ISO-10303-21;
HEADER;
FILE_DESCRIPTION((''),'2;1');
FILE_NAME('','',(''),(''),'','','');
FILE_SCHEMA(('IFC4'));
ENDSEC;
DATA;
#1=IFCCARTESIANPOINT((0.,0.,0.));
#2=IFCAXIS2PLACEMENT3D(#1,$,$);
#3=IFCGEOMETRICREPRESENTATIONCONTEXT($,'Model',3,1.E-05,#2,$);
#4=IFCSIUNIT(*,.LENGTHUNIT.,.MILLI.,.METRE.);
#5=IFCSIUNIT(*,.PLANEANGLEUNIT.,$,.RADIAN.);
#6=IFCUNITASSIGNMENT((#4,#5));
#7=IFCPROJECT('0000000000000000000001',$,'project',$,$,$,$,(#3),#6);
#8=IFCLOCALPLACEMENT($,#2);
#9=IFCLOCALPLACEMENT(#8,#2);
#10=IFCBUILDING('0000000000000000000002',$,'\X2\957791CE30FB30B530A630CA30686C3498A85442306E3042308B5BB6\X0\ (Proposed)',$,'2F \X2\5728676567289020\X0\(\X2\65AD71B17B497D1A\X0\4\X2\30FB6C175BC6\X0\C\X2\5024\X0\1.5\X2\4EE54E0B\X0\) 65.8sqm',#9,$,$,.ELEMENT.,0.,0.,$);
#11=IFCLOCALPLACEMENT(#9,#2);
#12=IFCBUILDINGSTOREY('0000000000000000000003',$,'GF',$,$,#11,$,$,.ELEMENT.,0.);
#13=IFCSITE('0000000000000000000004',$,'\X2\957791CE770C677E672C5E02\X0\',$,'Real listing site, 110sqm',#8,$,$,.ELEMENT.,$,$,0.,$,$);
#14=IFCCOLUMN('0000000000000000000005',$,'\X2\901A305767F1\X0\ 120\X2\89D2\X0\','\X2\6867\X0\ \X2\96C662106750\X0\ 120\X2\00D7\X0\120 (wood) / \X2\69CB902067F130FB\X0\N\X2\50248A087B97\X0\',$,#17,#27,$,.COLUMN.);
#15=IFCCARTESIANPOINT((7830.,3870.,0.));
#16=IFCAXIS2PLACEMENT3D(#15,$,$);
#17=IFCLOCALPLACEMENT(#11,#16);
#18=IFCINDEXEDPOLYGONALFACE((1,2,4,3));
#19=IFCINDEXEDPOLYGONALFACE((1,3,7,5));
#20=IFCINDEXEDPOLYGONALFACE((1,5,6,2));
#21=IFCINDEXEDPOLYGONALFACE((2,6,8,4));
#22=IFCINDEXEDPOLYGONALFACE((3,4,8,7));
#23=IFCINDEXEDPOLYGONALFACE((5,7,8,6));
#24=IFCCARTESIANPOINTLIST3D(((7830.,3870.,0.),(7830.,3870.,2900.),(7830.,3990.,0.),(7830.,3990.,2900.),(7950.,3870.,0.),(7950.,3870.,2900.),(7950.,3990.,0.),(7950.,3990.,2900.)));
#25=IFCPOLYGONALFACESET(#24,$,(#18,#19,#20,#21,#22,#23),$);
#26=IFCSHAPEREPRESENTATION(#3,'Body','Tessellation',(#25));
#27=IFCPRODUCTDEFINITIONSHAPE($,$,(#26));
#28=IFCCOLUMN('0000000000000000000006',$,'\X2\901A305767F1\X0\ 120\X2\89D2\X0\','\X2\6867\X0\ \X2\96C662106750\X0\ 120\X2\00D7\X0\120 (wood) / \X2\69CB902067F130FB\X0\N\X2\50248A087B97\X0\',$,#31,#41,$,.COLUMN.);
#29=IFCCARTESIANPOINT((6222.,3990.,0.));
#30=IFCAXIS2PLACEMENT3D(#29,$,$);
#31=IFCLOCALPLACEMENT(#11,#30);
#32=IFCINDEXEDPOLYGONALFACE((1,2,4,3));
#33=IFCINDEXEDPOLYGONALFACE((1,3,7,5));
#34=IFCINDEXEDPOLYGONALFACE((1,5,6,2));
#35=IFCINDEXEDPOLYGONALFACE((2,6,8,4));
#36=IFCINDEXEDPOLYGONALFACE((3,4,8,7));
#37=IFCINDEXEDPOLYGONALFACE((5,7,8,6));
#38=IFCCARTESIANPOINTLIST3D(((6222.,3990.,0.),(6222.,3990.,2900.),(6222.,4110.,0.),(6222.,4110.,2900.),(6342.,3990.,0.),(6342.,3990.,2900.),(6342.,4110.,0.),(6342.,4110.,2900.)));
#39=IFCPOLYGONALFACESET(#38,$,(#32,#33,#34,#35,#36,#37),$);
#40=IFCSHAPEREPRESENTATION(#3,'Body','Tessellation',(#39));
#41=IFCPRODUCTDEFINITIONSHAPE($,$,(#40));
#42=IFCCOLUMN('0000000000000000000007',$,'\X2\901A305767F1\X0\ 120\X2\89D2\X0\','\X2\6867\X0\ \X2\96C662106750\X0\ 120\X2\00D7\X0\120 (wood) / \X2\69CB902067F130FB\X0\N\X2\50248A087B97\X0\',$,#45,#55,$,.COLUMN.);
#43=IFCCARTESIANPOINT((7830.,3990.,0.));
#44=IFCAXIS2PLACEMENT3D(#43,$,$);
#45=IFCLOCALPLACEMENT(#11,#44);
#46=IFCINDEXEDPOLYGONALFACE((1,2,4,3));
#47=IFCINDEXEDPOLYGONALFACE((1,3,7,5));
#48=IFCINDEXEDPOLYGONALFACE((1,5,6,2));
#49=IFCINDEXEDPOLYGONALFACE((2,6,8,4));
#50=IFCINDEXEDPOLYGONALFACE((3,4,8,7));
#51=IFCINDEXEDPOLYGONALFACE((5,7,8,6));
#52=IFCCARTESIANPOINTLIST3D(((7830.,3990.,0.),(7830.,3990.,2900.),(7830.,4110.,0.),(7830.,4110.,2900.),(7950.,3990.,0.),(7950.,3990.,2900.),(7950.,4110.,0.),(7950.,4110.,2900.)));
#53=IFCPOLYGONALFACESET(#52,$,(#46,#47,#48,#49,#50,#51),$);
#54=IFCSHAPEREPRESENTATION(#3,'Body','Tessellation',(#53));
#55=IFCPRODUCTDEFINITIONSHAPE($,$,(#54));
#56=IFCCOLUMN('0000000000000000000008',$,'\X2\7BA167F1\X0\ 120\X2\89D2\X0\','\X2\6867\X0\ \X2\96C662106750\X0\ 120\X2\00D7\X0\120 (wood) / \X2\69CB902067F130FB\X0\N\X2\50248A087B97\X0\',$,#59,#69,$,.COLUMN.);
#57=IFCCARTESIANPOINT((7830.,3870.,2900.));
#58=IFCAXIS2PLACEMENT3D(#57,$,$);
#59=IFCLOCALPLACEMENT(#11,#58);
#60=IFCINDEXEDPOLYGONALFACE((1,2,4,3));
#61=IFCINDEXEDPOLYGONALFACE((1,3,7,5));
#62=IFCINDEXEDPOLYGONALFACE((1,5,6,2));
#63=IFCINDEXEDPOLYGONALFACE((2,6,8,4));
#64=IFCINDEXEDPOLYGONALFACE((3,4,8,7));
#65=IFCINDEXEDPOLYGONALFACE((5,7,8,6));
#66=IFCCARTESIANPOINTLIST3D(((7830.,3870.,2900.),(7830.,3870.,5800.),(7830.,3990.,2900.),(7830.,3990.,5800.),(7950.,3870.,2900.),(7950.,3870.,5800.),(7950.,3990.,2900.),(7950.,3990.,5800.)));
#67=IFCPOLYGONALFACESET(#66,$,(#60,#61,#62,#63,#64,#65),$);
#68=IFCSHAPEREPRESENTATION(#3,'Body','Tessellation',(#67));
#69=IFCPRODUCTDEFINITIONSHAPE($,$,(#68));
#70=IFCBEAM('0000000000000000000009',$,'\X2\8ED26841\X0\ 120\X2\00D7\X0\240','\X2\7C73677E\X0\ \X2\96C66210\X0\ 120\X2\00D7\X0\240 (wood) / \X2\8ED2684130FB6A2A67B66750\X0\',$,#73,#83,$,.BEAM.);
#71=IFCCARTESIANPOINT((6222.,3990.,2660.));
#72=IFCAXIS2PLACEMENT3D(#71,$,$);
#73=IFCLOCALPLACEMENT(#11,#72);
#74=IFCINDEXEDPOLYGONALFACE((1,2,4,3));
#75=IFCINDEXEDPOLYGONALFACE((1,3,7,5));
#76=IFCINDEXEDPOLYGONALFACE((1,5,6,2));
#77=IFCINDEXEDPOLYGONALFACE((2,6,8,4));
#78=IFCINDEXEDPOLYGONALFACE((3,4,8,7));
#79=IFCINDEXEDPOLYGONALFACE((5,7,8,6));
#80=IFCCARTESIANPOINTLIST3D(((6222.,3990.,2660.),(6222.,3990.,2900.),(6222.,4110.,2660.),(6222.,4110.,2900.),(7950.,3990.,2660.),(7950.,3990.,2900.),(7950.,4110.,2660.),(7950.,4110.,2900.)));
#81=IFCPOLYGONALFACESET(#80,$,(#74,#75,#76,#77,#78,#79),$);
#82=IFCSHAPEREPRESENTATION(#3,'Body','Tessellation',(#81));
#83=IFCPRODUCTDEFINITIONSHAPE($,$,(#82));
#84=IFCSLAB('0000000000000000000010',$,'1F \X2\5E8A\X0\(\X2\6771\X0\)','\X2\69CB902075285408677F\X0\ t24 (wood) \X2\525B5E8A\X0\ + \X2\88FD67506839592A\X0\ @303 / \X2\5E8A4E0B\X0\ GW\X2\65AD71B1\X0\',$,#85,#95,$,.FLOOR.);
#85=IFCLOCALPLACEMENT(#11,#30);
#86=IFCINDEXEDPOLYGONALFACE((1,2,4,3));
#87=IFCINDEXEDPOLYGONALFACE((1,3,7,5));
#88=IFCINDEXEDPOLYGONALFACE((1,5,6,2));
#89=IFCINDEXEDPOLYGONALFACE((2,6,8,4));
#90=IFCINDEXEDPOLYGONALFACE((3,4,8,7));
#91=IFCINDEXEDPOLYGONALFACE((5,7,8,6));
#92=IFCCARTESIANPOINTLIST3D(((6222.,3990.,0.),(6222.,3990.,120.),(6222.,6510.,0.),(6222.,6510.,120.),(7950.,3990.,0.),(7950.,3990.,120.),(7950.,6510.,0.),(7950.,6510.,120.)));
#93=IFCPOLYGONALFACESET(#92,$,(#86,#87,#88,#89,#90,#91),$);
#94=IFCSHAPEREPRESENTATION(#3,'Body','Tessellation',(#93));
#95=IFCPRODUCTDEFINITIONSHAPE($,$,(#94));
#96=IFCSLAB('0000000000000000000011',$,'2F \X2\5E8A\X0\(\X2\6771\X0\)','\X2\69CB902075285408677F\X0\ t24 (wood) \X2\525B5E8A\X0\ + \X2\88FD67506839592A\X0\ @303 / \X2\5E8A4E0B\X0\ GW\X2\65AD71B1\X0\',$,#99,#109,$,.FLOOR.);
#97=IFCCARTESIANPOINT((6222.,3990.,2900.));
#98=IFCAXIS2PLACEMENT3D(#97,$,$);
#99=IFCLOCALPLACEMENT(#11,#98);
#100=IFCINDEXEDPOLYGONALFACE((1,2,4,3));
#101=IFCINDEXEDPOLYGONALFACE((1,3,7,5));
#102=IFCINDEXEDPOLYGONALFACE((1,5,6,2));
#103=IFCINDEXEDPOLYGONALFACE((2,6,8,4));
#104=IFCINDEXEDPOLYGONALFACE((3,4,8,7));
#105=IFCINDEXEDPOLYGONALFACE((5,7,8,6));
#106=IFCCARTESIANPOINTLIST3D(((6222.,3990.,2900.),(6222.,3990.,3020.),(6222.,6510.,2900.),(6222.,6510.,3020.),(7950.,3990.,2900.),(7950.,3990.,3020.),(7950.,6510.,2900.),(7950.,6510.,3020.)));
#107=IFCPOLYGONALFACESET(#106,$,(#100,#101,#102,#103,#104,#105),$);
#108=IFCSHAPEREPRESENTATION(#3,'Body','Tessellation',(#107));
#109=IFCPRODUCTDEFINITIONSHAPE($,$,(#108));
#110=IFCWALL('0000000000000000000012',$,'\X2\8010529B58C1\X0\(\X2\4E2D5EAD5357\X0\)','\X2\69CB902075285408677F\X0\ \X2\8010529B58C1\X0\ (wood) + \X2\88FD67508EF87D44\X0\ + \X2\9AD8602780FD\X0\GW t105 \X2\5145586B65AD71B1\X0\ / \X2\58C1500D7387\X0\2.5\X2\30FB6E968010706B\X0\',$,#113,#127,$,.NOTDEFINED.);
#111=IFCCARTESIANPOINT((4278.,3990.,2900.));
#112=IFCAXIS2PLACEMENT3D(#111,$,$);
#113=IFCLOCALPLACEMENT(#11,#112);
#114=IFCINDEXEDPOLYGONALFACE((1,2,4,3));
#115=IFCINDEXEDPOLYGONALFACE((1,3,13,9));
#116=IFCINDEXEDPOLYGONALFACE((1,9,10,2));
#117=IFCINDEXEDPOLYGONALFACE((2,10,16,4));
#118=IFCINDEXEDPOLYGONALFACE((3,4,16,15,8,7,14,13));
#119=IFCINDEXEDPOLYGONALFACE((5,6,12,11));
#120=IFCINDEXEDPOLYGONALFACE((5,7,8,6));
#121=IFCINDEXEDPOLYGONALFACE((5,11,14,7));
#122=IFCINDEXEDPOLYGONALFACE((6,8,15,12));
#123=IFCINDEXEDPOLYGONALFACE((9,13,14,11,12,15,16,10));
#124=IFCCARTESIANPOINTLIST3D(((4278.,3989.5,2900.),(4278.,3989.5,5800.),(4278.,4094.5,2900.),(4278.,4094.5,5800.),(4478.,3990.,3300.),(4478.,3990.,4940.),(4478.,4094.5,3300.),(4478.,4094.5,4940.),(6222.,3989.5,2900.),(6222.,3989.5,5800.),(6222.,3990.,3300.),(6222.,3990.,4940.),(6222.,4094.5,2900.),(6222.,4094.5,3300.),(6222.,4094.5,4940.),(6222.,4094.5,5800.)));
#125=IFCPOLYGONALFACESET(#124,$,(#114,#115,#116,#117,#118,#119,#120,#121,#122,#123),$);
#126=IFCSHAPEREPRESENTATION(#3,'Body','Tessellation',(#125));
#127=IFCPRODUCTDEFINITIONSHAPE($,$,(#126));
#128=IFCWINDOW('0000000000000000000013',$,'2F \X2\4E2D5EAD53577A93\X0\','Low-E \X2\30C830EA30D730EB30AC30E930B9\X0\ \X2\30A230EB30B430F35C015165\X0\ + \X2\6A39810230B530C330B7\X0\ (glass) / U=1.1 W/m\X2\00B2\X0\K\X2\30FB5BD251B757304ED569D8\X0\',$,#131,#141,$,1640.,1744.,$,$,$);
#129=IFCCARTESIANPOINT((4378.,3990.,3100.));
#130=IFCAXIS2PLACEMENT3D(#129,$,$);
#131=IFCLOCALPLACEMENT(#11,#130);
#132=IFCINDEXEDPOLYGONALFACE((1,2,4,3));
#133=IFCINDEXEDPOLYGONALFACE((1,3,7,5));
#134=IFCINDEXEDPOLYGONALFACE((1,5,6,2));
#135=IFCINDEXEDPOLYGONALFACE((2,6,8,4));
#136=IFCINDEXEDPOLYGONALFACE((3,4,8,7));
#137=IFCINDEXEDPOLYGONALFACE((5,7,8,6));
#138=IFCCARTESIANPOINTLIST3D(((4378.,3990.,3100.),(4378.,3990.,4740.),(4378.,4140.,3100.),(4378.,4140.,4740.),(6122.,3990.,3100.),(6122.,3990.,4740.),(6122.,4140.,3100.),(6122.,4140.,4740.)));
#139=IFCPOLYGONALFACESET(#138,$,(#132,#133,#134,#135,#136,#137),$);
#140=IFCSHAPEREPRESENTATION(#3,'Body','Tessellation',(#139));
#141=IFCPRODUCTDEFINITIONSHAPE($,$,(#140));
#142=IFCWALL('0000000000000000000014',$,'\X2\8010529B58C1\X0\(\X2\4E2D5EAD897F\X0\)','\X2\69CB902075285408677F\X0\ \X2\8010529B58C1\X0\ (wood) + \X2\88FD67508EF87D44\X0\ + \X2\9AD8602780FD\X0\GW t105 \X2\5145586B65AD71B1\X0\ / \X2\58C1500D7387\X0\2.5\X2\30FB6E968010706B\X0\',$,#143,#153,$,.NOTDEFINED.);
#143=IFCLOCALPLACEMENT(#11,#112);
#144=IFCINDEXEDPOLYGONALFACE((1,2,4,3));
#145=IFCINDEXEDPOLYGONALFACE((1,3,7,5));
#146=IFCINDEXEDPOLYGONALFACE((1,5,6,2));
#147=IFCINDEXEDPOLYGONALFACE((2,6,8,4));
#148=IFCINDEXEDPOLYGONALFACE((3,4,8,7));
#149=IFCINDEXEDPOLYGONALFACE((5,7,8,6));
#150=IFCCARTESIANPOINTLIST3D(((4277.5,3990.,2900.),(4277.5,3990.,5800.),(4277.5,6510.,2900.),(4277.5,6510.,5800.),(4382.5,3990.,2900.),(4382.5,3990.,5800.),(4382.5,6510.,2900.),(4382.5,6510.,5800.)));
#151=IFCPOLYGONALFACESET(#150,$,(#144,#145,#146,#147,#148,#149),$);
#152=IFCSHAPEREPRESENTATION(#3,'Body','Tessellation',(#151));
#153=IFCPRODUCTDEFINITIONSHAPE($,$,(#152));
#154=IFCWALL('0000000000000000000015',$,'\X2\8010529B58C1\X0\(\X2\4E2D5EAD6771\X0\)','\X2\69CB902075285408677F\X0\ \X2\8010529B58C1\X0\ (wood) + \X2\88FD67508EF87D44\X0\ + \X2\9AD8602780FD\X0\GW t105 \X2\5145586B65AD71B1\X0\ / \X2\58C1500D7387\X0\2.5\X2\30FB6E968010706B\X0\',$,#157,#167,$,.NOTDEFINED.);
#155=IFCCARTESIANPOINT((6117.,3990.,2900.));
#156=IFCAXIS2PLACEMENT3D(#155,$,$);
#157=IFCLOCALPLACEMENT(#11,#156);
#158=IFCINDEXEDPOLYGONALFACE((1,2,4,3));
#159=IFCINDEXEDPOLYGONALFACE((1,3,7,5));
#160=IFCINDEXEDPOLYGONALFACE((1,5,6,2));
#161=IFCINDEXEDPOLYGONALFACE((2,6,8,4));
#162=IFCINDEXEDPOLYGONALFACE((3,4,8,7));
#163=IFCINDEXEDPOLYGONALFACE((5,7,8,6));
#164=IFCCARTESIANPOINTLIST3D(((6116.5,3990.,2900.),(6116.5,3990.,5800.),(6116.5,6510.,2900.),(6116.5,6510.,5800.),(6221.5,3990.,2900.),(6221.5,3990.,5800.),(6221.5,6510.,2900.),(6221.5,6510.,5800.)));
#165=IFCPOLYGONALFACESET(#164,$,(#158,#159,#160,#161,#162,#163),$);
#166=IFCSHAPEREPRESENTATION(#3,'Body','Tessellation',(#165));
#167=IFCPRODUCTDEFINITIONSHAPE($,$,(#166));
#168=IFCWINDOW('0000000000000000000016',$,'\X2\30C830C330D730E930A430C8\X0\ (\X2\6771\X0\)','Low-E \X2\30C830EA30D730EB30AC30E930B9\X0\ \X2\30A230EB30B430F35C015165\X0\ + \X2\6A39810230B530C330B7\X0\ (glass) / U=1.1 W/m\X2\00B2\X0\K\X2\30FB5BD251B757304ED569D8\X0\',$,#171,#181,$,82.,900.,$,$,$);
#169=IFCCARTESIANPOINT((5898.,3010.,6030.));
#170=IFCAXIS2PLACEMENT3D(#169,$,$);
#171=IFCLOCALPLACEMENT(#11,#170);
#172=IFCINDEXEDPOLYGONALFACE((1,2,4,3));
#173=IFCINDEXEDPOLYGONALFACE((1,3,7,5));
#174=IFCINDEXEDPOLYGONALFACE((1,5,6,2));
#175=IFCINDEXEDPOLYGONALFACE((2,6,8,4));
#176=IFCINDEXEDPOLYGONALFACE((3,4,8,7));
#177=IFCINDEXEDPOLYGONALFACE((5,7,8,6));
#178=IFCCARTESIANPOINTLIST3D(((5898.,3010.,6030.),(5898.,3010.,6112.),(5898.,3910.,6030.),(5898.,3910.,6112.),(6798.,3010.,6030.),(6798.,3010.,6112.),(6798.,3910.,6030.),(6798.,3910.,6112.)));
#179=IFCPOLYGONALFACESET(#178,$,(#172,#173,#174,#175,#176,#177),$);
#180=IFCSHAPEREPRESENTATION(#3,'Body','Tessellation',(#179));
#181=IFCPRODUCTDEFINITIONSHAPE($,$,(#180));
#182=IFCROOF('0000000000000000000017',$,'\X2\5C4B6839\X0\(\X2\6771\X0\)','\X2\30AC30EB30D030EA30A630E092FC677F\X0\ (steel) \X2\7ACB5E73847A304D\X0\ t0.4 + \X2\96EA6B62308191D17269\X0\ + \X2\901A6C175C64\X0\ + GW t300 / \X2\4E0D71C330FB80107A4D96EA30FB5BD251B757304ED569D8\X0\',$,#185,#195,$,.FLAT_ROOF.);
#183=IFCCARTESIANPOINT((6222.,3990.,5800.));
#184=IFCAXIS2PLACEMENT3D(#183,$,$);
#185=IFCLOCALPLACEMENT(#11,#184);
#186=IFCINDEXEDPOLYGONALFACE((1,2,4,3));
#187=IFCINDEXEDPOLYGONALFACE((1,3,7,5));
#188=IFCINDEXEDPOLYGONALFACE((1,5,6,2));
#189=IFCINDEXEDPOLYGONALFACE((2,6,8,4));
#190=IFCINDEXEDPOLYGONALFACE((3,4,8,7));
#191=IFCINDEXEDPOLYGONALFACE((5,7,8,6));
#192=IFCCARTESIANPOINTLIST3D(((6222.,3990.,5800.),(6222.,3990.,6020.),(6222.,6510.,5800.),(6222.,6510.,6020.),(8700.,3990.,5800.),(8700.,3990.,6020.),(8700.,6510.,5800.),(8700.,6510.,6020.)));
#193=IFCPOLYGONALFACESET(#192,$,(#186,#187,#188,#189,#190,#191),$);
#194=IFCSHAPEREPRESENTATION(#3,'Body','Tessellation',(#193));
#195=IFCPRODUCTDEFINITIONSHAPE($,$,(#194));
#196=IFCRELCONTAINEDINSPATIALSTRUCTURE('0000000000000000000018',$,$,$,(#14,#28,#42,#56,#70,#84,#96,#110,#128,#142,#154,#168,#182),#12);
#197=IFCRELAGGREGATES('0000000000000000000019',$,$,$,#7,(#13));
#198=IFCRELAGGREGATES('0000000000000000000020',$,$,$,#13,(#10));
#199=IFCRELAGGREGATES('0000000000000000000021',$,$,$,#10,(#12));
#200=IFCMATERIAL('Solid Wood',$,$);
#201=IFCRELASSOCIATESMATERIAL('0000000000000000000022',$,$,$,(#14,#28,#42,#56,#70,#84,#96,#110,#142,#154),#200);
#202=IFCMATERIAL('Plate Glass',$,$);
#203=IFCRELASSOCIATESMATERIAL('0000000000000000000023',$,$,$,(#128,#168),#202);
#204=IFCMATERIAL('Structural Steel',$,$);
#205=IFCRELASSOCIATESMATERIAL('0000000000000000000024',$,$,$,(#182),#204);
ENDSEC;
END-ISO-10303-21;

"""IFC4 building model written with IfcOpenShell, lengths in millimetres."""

from ifc_helpers import new_model, si_unit, frame, frame_2d, origin, place, context, project, spatial, rectangle, extrude, material, element, fill, save


model = new_model("IFC4")

# Units and contexts
model_context = context("Model", 3, precision=1e-05, world=origin())
ifc_project = project(units=[si_unit("LENGTHUNIT", "METRE", prefix="MILLI"), si_unit("PLANEANGLEUNIT", "RADIAN")], contexts=[model_context])

# Site, building, storey
site_placement = place(None, origin())
site = spatial("IfcSite", under=ifc_project, at=site_placement, Name="長野県松本市", ObjectType="Real listing site, 110sqm", CompositionType="ELEMENT", RefElevation=0.0)
building_placement = place(site_placement, origin())
building = spatial("IfcBuilding", under=site, at=building_placement, Name="長野・サウナと水風呂のある家 (Proposed)", ObjectType="2F 在来木造(断熱等級4・気密C値1.5以下) 65.8sqm", CompositionType="ELEMENT", ElevationOfRefHeight=0.0, ElevationOfTerrain=0.0)
storey_placement = place(building_placement, origin())
storey = spatial("IfcBuildingStorey", under=building, at=storey_placement, Name="GF", CompositionType="ELEMENT", Elevation=0.0)

# Columns
ifc_material_1 = material(Name="Solid Wood")
column_1_placement = place(storey_placement, frame((7830.0, 3870.0, 0.0)))
element("IfcColumn", 1, at=column_1_placement, inside=storey, material=ifc_material_1, Name="通し柱 120角", Description="桧 集成材 120×120 (wood) / 構造柱・N値計算", PredefinedType="COLUMN", context=model_context, shape_type="SweptSolid", body=[
    extrude(rectangle(XDim=120.0, YDim=120.0, at=frame_2d((60.0, 60.0))), frame((7830.0, 3870.0, 0.0)), (0.0, 0.0, 1.0), 2900.0),
])
column_2_placement = place(storey_placement, frame((6222.0, 3990.0, 0.0)))
element("IfcColumn", 2, at=column_2_placement, inside=storey, material=ifc_material_1, Name="通し柱 120角", Description="桧 集成材 120×120 (wood) / 構造柱・N値計算", PredefinedType="COLUMN", context=model_context, shape_type="SweptSolid", body=[
    extrude(rectangle(XDim=120.0, YDim=120.0, at=frame_2d((60.0, 60.0))), frame((6222.0, 3990.0, 0.0)), (0.0, 0.0, 1.0), 2900.0),
])
column_3_placement = place(storey_placement, frame((7830.0, 3990.0, 0.0)))
element("IfcColumn", 3, at=column_3_placement, inside=storey, material=ifc_material_1, Name="通し柱 120角", Description="桧 集成材 120×120 (wood) / 構造柱・N値計算", PredefinedType="COLUMN", context=model_context, shape_type="SweptSolid", body=[
    extrude(rectangle(XDim=120.0, YDim=120.0, at=frame_2d((60.0, 60.0))), frame((7830.0, 3990.0, 0.0)), (0.0, 0.0, 1.0), 2900.0),
])
column_4_placement = place(storey_placement, frame((7830.0, 3870.0, 2900.0)))
element("IfcColumn", 4, at=column_4_placement, inside=storey, material=ifc_material_1, Name="管柱 120角", Description="桧 集成材 120×120 (wood) / 構造柱・N値計算", PredefinedType="COLUMN", context=model_context, shape_type="SweptSolid", body=[
    extrude(rectangle(XDim=120.0, YDim=120.0, at=frame_2d((60.0, 60.0))), frame((7830.0, 3870.0, 2900.0)), (0.0, 0.0, 1.0), 2900.0),
])

# Beam
beam_1_placement = place(storey_placement, frame((6222.0, 3990.0, 2660.0)))
element("IfcBeam", 5, at=beam_1_placement, inside=storey, material=ifc_material_1, Name="軒桁 120×240", Description="米松 集成 120×240 (wood) / 軒桁・横架材", PredefinedType="BEAM", context=model_context, shape_type="SweptSolid", body=[
    extrude(rectangle(XDim=1728.0, YDim=120.0, at=frame_2d((864.0, 60.0))), frame((6222.0, 3990.0, 2660.0)), (0.0, 0.0, 1.0), 240.0),
])

# Slabs
slab_1_placement = place(storey_placement, frame((6222.0, 3990.0, 0.0)))
element("IfcSlab", 6, at=slab_1_placement, inside=storey, material=ifc_material_1, Name="1F 床(東)", Description="構造用合板 t24 (wood) 剛床 + 製材根太 @303 / 床下 GW断熱", PredefinedType="FLOOR", context=model_context, shape_type="SweptSolid", body=[
    extrude(rectangle(XDim=1728.0, YDim=2520.0, at=frame_2d((864.0, 1260.0))), frame((6222.0, 3990.0, 0.0)), (0.0, 0.0, 1.0), 120.0),
])
slab_2_placement = place(storey_placement, frame((6222.0, 3990.0, 2900.0)))
element("IfcSlab", 7, at=slab_2_placement, inside=storey, material=ifc_material_1, Name="2F 床(東)", Description="構造用合板 t24 (wood) 剛床 + 製材根太 @303 / 床下 GW断熱", PredefinedType="FLOOR", context=model_context, shape_type="SweptSolid", body=[
    extrude(rectangle(XDim=1728.0, YDim=2520.0, at=frame_2d((864.0, 1260.0))), frame((6222.0, 3990.0, 2900.0)), (0.0, 0.0, 1.0), 120.0),
])

# Wall, opening, window
wall_1_placement = place(storey_placement, frame((4278.0, 3990.0, 2900.0)))
wall_1 = element("IfcWall", 8, at=wall_1_placement, inside=storey, material=ifc_material_1, Name="耐力壁(中庭南)", Description="構造用合板 耐力壁 (wood) + 製材軸組 + 高性能GW t105 充填断熱 / 壁倍率2.5・準耐火", PredefinedType="NOTDEFINED", context=model_context, shape_type="SweptSolid", body=[
    extrude(rectangle(XDim=1944.0, YDim=105.0, at=frame_2d((972.0, 52.0))), frame((4278.0, 3990.0, 2900.0)), (0.0, 0.0, 1.0), 2900.0),
])
opening_placement = place(storey_placement, frame((4378.0, 3990.0, 3100.0)))
opening = element("IfcOpeningElement", 9, at=opening_placement, cuts=wall_1, PredefinedType="NOTDEFINED", context=model_context, shape_type="SweptSolid", body=[
    extrude(rectangle(XDim=1744.0, YDim=150.0, at=frame_2d((872.0, 75.0))), frame((4378.0, 3990.0, 3100.0)), (0.0, 0.0, 1.0), 1640.0),
])
ifc_material_2 = material(Name="Plate Glass")
window_1_placement = place(storey_placement, frame((4378.0, 3990.0, 3100.0)))
window_1 = element("IfcWindow", 10, at=window_1_placement, inside=storey, material=ifc_material_2, Name="2F 中庭南窓", Description="Low-E トリプルガラス アルゴン封入 + 樹脂サッシ (glass) / U=1.1 W/m²K・寒冷地仕様", OverallHeight=1640.0, OverallWidth=1744.0, context=model_context, shape_type="SweptSolid", body=[
    extrude(rectangle(XDim=1744.0, YDim=150.0, at=frame_2d((872.0, 75.0))), frame((4378.0, 3990.0, 3100.0)), (0.0, 0.0, 1.0), 1640.0),
])
fill(opening, window_1)

# Walls
wall_2_placement = place(storey_placement, frame((4278.0, 3990.0, 2900.0)))
element("IfcWall", 11, at=wall_2_placement, inside=storey, material=ifc_material_1, Name="耐力壁(中庭西)", Description="構造用合板 耐力壁 (wood) + 製材軸組 + 高性能GW t105 充填断熱 / 壁倍率2.5・準耐火", PredefinedType="NOTDEFINED", context=model_context, shape_type="SweptSolid", body=[
    extrude(rectangle(XDim=105.0, YDim=2520.0, at=frame_2d((52.0, 1260.0))), frame((4278.0, 3990.0, 2900.0)), (0.0, 0.0, 1.0), 2900.0),
])
wall_3_placement = place(storey_placement, frame((6117.0, 3990.0, 2900.0)))
element("IfcWall", 12, at=wall_3_placement, inside=storey, material=ifc_material_1, Name="耐力壁(中庭東)", Description="構造用合板 耐力壁 (wood) + 製材軸組 + 高性能GW t105 充填断熱 / 壁倍率2.5・準耐火", PredefinedType="NOTDEFINED", context=model_context, shape_type="SweptSolid", body=[
    extrude(rectangle(XDim=105.0, YDim=2520.0, at=frame_2d((52.0, 1260.0))), frame((6117.0, 3990.0, 2900.0)), (0.0, 0.0, 1.0), 2900.0),
])

# Window
window_2_placement = place(storey_placement, frame((5898.0, 3010.0, 6030.0)))
element("IfcWindow", 13, at=window_2_placement, inside=storey, material=ifc_material_2, Name="トップライト (東)", Description="Low-E トリプルガラス アルゴン封入 + 樹脂サッシ (glass) / U=1.1 W/m²K・寒冷地仕様", OverallHeight=82.0, OverallWidth=900.0, context=model_context, shape_type="SweptSolid", body=[
    extrude(rectangle(XDim=900.0, YDim=900.0, at=frame_2d((450.0, 450.0))), frame((5898.0, 3010.0, 6030.0)), (0.0, 0.0, 1.0), 82.0),
])

# Roof
ifc_material_3 = material(Name="Structural Steel")
for number, where, name in (
    (14, (6222.0, 3990.0, 5800.0), "屋根(東)"),
):
    element("IfcRoof", number, at=place(storey_placement, frame(where)), inside=storey, material=ifc_material_3, Name=name, Description="ガルバリウム鋼板 (steel) 立平葺き t0.4 + 雪止め金物 + 通気層 + GW t300 / 不燃・耐積雪・寒冷地仕様", PredefinedType="FLAT_ROOF", context=model_context, shape_type="SweptSolid", body=[
        extrude(rectangle(XDim=2478.0, YDim=2520.0, at=frame_2d((1239.0, 1260.0))), frame((6222.0, 3990.0, 5800.0)), (0.0, 0.0, 1.0), 220.0),
    ])

save(model, "model.ifc")
